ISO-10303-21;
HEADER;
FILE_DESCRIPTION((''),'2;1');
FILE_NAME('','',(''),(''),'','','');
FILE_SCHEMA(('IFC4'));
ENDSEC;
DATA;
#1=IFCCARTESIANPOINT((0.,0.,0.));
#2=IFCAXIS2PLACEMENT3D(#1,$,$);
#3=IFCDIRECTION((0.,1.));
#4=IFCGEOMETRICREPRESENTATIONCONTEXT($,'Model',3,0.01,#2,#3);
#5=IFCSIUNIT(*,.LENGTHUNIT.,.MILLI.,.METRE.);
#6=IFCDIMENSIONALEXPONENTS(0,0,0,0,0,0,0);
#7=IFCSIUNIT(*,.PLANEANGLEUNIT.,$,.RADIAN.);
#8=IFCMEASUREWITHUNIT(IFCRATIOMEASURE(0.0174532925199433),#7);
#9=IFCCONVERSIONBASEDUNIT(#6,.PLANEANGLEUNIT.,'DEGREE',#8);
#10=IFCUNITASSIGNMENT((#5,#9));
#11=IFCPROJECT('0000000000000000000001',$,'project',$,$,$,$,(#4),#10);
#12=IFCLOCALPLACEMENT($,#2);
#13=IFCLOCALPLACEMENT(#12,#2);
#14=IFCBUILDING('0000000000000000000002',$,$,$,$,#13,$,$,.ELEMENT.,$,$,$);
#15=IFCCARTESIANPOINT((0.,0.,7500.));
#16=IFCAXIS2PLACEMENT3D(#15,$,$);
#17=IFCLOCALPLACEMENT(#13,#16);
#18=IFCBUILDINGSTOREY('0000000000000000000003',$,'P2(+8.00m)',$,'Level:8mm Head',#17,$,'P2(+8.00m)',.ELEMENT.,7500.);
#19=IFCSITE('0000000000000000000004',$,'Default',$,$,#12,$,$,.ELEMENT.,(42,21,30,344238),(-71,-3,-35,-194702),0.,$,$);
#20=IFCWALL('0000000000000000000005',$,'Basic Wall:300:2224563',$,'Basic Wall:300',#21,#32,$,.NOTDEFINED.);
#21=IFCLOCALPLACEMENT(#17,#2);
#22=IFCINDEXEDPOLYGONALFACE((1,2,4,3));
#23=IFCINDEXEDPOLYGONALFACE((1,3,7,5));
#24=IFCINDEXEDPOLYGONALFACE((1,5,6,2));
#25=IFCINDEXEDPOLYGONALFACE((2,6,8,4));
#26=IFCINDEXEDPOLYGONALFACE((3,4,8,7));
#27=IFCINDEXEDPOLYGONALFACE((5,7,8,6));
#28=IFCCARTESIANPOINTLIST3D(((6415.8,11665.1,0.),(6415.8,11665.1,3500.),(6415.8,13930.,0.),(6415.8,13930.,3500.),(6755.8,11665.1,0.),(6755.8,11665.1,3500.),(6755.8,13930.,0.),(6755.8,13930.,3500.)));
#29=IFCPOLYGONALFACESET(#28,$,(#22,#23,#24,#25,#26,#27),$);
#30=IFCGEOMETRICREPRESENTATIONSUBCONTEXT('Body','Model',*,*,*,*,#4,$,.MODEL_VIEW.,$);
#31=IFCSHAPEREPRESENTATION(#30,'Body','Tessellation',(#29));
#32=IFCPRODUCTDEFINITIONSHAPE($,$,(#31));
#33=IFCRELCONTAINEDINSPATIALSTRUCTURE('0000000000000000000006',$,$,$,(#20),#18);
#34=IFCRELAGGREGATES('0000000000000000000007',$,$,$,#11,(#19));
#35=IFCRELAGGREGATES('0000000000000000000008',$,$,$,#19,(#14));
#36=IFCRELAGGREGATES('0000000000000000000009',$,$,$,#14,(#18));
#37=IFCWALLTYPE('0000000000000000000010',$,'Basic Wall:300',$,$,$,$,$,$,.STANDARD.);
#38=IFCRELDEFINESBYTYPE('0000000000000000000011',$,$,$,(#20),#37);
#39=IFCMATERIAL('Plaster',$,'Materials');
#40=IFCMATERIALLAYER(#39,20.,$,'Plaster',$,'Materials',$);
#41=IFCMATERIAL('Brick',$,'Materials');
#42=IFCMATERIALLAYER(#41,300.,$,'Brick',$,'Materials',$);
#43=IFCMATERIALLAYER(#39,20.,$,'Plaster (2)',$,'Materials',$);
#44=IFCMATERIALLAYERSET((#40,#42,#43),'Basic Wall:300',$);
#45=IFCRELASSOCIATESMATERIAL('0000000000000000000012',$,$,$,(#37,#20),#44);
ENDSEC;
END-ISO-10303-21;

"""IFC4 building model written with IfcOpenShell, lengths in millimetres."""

from ifc_helpers import new_model, entity, si_unit, converted_unit, direction, frame, frame_2d, origin, place, context, subcontext, project, spatial, rectangle, extrude, material, layer, layer_set, layer_usage, type_object, element, save


model = new_model("IFC4")

# Units and contexts
model_context = context("Model", 3, precision=0.01, world=origin(), true_north=direction((0.0, 1.0)))
body_context = subcontext(model_context, "Body", "Model", "MODEL_VIEW")
ifc_project = project(units=[si_unit("LENGTHUNIT", "METRE", prefix="MILLI"), converted_unit("PLANEANGLEUNIT", "DEGREE", entity("IfcRatioMeasure", 0.0174532925199433), si_unit("PLANEANGLEUNIT", "RADIAN"), dimensions=[0, 0, 0, 0, 0, 0, 0])], contexts=[model_context])

# Site, building, storey
site_placement = place(None, origin())
site = spatial("IfcSite", under=ifc_project, at=site_placement, Name="Default", CompositionType="ELEMENT", RefLatitude=(42, 21, 30, 344238), RefLongitude=(-71, -3, -35, -194702), RefElevation=0.0)
building_placement = place(site_placement, origin())
building = spatial("IfcBuilding", under=site, at=building_placement, CompositionType="ELEMENT")
storey_placement = place(building_placement, frame((0.0, 0.0, 7500.0)))
storey = spatial("IfcBuildingStorey", under=building, at=storey_placement, Name="P2(+8.00m)", ObjectType="Level:8mm Head", LongName="P2(+8.00m)", CompositionType="ELEMENT", Elevation=7500.0)

# Shared definitions
ifc_material_1 = material(Name="Brick", Category="Materials")
ifc_material_2 = material(Name="Plaster", Category="Materials")

# Shared definitions
ifc_layer_1 = layer(ifc_material_2, 20.0, Name="Plaster", Category="Materials")
ifc_layer_2 = layer(ifc_material_1, 300.0, Name="Brick", Category="Materials")
ifc_layer_3 = layer(ifc_material_2, 20.0, Name="Plaster (2)", Category="Materials")
ifc_layer_set_1 = layer_set([ifc_layer_1, ifc_layer_2, ifc_layer_3], Name="Basic Wall:300")
wall_type_1 = type_object("IfcWallType", Name="Basic Wall:300", PredefinedType="STANDARD", material=ifc_layer_set_1)

# Wall
ifc_layer_usage_1 = layer_usage(ifc_layer_set_1, "AXIS2", "NEGATIVE", 170.0)
wall_1_placement = place(storey_placement, frame((6585.8, 11665.1, 0.0), z_axis=(0.0, 0.0, 1.0), x_axis=(0.0, 1.0, 0.0)))
element("IfcWall", 1, at=wall_1_placement, inside=storey, type_object=wall_type_1, material=ifc_layer_usage_1, Name="Basic Wall:300:2224563", ObjectType="Basic Wall:300", PredefinedType="NOTDEFINED", context=body_context, shape_type="SweptSolid", body=[
    extrude(rectangle(XDim=2264.9, YDim=340.0, at=frame_2d((1132.5, 0.0), x_axis=(-1.0, 0.0))), origin(), (0.0, 0.0, 1.0), 3500.0),
])

save(model, "model.ifc")
